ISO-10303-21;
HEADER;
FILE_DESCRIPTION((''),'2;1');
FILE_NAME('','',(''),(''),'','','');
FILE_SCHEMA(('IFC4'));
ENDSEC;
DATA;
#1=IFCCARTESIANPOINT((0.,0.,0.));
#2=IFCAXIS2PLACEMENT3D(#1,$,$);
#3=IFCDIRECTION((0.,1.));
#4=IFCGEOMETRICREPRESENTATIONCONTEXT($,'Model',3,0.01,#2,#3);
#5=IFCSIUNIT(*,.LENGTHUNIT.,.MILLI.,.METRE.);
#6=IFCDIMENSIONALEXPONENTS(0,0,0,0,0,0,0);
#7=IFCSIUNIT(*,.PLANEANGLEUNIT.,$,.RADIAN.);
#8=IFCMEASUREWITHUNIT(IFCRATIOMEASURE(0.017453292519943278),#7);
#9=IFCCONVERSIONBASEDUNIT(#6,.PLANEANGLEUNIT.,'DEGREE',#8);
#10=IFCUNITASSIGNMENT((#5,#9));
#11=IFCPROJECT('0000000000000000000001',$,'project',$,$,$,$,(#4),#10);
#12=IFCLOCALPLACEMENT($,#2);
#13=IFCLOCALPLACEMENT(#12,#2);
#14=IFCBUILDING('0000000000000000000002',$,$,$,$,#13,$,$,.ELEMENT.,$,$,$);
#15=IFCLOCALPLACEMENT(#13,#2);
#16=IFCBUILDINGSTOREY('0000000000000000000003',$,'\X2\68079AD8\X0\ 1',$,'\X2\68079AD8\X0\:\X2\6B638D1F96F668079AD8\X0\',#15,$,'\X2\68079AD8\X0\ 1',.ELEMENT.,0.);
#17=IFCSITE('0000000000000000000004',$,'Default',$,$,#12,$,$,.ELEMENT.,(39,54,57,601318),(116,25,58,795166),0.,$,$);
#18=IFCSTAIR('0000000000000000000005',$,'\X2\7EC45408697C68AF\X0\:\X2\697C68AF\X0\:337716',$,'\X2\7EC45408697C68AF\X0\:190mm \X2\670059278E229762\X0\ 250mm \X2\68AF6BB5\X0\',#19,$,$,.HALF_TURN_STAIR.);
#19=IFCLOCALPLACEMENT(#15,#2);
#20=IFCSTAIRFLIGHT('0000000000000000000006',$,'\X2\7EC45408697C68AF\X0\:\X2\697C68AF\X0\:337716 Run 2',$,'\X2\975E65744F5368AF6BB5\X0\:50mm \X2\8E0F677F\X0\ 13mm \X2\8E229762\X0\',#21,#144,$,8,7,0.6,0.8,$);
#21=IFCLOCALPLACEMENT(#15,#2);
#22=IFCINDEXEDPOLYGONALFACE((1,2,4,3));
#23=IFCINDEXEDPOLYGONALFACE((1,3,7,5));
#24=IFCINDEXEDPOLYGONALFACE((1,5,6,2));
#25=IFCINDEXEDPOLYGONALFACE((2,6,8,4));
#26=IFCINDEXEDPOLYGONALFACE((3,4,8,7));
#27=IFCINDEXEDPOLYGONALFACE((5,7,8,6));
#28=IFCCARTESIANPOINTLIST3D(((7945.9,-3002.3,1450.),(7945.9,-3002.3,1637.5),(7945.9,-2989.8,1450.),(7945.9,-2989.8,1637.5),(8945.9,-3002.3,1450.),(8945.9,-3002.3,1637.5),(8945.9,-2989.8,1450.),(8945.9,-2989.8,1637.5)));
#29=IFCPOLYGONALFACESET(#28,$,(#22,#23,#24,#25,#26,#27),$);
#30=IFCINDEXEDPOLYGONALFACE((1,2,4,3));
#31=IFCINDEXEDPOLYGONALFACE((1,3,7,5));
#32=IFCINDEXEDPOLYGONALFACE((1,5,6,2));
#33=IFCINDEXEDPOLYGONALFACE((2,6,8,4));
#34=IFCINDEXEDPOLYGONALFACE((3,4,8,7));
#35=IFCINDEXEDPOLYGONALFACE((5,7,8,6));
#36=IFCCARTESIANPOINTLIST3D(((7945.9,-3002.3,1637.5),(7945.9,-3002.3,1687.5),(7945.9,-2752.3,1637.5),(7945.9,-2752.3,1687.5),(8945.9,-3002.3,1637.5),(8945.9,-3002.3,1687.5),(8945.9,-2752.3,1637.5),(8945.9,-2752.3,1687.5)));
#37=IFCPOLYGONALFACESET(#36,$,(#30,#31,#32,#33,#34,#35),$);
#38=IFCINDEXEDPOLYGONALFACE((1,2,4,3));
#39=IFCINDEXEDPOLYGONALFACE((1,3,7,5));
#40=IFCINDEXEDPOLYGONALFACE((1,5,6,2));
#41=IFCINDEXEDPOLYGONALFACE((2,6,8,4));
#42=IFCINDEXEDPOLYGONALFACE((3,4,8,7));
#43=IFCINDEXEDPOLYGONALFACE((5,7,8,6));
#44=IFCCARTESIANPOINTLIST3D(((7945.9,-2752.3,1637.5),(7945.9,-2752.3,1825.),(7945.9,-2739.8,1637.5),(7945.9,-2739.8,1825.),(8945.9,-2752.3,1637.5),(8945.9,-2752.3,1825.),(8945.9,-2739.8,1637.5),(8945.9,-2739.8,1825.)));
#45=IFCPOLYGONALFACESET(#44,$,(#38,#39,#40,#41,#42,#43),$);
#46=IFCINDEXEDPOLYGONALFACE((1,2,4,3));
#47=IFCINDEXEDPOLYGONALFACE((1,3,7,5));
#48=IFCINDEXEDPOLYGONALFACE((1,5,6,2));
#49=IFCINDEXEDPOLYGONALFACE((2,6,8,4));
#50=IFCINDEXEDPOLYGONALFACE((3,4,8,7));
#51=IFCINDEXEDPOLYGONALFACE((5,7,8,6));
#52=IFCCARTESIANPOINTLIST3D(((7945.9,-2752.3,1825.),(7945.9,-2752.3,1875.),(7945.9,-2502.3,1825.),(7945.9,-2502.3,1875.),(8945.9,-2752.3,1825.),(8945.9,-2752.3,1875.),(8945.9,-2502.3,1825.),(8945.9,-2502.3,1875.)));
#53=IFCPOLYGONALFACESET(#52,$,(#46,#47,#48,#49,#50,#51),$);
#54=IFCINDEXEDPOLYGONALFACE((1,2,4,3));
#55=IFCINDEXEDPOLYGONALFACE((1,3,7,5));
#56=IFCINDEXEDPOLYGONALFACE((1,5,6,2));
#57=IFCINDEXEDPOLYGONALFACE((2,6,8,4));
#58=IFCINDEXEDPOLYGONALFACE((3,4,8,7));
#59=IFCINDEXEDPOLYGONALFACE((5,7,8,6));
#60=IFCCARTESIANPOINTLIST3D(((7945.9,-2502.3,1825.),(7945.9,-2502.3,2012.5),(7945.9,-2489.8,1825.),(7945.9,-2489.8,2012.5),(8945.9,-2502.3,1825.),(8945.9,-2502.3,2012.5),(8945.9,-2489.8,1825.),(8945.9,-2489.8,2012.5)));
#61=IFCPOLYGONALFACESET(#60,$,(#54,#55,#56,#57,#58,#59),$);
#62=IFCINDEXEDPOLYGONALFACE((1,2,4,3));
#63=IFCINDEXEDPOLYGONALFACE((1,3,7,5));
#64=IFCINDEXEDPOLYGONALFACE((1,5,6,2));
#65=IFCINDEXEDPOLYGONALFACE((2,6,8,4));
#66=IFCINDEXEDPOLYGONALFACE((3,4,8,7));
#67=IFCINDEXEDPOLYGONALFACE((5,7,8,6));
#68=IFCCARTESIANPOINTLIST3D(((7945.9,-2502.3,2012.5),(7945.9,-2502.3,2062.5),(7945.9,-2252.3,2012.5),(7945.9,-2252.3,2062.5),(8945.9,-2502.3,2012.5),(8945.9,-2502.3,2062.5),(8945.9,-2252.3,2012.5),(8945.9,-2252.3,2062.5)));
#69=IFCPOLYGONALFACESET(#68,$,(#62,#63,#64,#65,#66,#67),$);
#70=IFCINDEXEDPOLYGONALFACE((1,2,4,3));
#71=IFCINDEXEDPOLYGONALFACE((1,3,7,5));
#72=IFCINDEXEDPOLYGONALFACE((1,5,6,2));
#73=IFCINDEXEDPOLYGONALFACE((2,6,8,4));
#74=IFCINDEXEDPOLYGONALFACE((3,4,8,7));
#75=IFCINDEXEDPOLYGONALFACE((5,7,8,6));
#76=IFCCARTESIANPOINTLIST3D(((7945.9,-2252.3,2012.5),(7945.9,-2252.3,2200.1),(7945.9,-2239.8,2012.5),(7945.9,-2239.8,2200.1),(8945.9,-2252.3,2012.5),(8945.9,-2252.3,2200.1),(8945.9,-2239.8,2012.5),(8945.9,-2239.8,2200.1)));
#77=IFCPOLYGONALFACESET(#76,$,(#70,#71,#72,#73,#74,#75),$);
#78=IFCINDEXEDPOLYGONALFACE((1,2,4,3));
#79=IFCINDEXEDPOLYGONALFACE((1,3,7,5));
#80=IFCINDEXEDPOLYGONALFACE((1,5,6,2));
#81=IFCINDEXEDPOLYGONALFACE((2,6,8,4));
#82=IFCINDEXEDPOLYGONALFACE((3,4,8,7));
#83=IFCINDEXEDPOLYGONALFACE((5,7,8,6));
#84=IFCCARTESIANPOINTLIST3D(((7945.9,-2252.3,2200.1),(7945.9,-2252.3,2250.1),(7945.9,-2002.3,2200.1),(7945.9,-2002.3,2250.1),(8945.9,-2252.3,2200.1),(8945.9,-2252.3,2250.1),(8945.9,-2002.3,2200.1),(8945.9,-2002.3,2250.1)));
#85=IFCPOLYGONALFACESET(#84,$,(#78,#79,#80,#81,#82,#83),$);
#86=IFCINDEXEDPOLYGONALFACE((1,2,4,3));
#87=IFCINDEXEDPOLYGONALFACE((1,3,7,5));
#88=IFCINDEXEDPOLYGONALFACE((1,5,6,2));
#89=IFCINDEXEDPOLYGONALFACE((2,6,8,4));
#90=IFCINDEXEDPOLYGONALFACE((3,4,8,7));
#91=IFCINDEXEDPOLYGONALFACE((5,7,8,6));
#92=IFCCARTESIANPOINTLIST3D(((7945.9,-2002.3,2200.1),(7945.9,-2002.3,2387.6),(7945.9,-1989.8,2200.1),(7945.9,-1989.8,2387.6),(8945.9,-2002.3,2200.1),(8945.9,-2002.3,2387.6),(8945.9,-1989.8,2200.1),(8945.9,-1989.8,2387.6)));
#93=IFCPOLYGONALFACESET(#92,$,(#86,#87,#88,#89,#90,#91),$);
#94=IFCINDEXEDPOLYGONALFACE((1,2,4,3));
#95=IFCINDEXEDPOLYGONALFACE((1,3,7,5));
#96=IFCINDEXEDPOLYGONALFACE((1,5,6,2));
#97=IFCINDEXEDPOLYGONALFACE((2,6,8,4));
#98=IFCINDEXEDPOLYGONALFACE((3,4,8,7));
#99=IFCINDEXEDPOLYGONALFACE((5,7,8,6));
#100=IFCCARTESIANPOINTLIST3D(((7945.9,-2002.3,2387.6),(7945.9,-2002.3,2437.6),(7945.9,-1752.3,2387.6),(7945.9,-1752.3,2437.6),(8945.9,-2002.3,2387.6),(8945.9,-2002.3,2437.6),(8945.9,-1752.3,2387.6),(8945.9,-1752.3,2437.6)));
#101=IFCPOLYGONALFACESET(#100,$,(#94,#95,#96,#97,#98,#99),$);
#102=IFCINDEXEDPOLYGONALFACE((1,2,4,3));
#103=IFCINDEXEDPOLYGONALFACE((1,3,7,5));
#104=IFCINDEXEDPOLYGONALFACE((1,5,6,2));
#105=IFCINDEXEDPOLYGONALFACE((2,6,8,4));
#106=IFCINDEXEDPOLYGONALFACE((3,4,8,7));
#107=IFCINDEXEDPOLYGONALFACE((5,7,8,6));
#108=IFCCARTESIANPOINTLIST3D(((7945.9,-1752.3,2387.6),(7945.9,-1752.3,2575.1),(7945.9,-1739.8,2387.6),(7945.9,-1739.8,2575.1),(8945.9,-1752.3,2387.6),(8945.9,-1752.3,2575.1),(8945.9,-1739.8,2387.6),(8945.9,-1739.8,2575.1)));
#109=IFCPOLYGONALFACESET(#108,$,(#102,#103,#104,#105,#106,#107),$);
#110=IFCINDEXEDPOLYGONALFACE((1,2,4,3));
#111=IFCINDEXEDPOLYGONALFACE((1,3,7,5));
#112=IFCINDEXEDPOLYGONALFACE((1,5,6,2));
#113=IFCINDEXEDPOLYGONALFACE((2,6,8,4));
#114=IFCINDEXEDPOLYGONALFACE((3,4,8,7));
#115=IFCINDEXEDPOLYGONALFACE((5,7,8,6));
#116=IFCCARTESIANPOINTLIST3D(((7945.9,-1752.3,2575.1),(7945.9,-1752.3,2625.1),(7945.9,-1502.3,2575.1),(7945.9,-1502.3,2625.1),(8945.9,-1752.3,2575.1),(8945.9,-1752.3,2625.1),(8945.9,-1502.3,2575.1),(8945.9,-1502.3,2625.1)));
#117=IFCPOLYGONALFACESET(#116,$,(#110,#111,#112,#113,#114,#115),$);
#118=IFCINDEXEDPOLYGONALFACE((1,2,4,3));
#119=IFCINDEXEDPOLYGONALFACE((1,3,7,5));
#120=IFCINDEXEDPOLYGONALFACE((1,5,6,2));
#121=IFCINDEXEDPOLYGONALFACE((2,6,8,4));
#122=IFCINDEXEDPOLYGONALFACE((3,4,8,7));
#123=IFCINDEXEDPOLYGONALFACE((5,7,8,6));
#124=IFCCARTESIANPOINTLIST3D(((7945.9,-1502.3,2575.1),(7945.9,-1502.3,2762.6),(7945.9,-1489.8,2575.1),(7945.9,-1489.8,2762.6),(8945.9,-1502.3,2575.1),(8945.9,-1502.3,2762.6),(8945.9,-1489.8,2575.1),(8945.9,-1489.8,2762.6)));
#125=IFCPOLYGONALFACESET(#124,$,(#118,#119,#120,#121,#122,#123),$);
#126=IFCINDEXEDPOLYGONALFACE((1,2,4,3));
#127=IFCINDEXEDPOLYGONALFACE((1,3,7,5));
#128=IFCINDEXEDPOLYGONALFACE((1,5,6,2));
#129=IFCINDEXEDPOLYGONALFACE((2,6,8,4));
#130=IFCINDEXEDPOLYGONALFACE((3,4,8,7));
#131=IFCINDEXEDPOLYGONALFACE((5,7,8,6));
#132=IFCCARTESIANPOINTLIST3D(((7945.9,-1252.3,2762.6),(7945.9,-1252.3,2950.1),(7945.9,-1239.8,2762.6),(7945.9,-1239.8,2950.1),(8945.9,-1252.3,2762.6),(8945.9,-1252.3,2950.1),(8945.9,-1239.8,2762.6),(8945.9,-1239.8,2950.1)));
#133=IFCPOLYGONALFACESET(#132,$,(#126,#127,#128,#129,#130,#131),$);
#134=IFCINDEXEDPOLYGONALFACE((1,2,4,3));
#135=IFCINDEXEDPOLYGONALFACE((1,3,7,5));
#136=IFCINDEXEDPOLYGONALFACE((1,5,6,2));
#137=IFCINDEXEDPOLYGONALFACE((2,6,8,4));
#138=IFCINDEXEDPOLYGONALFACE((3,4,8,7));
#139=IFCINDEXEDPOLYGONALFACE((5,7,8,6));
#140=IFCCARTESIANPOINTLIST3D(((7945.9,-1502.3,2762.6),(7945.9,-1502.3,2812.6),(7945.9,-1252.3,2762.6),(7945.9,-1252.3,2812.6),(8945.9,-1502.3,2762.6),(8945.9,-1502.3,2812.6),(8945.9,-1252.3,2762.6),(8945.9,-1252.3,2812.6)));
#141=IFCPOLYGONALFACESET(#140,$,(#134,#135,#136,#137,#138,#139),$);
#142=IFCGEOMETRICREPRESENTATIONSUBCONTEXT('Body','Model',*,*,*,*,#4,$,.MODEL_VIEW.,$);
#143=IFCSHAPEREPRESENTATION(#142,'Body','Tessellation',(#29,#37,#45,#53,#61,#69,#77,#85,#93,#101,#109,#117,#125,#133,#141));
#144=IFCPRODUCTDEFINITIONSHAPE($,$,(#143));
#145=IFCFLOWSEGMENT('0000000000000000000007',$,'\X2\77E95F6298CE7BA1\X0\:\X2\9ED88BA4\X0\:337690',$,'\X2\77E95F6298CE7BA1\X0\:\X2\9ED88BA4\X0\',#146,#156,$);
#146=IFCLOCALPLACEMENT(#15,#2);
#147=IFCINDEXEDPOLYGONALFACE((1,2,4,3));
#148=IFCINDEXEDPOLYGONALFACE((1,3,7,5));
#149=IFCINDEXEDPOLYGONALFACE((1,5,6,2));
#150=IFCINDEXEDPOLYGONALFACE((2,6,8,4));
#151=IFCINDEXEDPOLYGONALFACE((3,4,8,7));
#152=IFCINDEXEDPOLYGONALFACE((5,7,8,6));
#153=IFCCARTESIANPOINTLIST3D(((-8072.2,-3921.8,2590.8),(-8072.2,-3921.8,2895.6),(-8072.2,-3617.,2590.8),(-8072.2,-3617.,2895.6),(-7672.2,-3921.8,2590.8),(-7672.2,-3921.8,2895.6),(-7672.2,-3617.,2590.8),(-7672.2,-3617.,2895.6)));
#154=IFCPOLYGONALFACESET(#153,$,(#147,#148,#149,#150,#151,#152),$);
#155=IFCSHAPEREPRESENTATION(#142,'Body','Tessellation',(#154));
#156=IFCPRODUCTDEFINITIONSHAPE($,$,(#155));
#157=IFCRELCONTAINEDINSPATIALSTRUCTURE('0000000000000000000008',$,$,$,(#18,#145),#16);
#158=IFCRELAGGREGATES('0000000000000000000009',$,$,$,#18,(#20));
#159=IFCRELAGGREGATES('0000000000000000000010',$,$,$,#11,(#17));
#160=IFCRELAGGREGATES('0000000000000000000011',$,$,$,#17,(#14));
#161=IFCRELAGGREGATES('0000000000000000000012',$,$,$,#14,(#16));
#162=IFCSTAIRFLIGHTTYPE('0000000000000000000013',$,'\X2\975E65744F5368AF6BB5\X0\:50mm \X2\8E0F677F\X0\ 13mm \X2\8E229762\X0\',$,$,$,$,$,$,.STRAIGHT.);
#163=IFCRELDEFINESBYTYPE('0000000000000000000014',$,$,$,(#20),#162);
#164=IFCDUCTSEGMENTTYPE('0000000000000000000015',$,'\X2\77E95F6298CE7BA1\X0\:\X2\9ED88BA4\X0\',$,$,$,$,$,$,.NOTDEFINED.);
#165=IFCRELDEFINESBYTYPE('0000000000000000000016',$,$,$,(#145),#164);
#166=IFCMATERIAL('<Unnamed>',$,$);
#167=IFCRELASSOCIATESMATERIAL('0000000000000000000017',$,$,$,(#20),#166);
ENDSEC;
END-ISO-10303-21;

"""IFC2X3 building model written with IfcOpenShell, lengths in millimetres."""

from ifc_helpers import new_model, entity, si_unit, converted_unit, direction, frame, frame_2d, origin, origin_2d_with_axis, place, context, subcontext, project, spatial, rectangle, extrude, material, type_object, element, aggregate, save


model = new_model("IFC2X3")

# Units and contexts
model_context = context("Model", 3, precision=0.01, world=origin(), true_north=direction((0.0, 1.0)))
body_context = subcontext(model_context, "Body", "Model", "MODEL_VIEW")
ifc_project = project(units=[si_unit("LENGTHUNIT", "METRE", prefix="MILLI"), converted_unit("PLANEANGLEUNIT", "DEGREE", entity("IfcRatioMeasure", 0.017453292519943278), si_unit("PLANEANGLEUNIT", "RADIAN"), dimensions=[0, 0, 0, 0, 0, 0, 0])], contexts=[model_context])

# Site, building, storey
site_placement = place(None, origin())
site = spatial("IfcSite", under=ifc_project, at=site_placement, Name="Default", CompositionType="ELEMENT", RefLatitude=(39, 54, 57, 601318), RefLongitude=(116, 25, 58, 795166), RefElevation=0.0)
building_placement = place(site_placement, origin())
building = spatial("IfcBuilding", under=site, at=building_placement, CompositionType="ELEMENT")
storey_placement = place(building_placement, origin())
storey = spatial("IfcBuildingStorey", under=building, at=storey_placement, Name="标高 1", ObjectType="标高:正负零标高", LongName="标高 1", CompositionType="ELEMENT", Elevation=0.0)

# Stair
stair_placement = place(storey_placement, origin())
stair = element("IfcStair", 1, at=stair_placement, inside=storey, Name="组合楼梯:楼梯:337716", ObjectType="组合楼梯:190mm 最大踢面 250mm 梯段", ShapeType="HALF_TURN_STAIR")
ifc_material_1 = material(Name="<Unnamed>")

# Stair flight
stair_flight_type = type_object("IfcStairFlightType", Name="非整体梯段:50mm 踏板 13mm 踢面", PredefinedType="STRAIGHT")
stair_flight_1_placement = place(stair_placement, origin())
stair_flight_1 = element("IfcStairFlight", 2, at=stair_flight_1_placement, type_object=stair_flight_type, material=ifc_material_1, Name="组合楼梯:楼梯:337716 Run 2", ObjectType="非整体梯段:50mm 踏板 13mm 踢面", NumberOfRiser=8, NumberOfTreads=7, RiserHeight=0.6, TreadLength=0.8, context=body_context, shape_type="SweptSolid", body=[
    extrude(rectangle(XDim=1000.0, YDim=12.5, at=frame_2d((0.0, 0.0), x_axis=(1.0, 0.0))), frame((8445.9, -2996.0, 1450.0), z_axis=(0.0, 0.0, 1.0), x_axis=(-1.0, 0.0, 0.0)), (0.0, 0.0, 1.0), 187.5),
    extrude(rectangle(XDim=250.0, YDim=1000.0, at=frame_2d((0.0, 0.0), x_axis=(1.0, 0.0))), frame((8445.9, -2877.3, 1637.5), z_axis=(0.0, 0.0, 1.0), x_axis=(0.0, -1.0, 0.0)), (0.0, 0.0, 1.0), 50.0),
    extrude(rectangle(XDim=1000.0, YDim=12.5, at=frame_2d((0.0, 0.0), x_axis=(1.0, 0.0))), frame((8445.9, -2746.0, 1637.5), z_axis=(0.0, 0.0, 1.0), x_axis=(-1.0, 0.0, 0.0)), (0.0, 0.0, 1.0), 187.5),
    extrude(rectangle(XDim=250.0, YDim=1000.0, at=frame_2d((0.0, 0.0), x_axis=(1.0, 0.0))), frame((8445.9, -2627.3, 1825.0), z_axis=(0.0, 0.0, 1.0), x_axis=(0.0, -1.0, 0.0)), (0.0, 0.0, 1.0), 50.0),
    extrude(rectangle(XDim=1000.0, YDim=12.5, at=frame_2d((0.0, 0.0), x_axis=(1.0, 0.0))), frame((8445.9, -2496.0, 1825.0), z_axis=(0.0, 0.0, 1.0), x_axis=(-1.0, 0.0, 0.0)), (0.0, 0.0, 1.0), 187.5),
    extrude(rectangle(XDim=250.0, YDim=1000.0, at=frame_2d((0.0, 0.0), x_axis=(1.0, 0.0))), frame((8445.9, -2377.3, 2012.5), z_axis=(0.0, 0.0, 1.0), x_axis=(0.0, -1.0, 0.0)), (0.0, 0.0, 1.0), 50.0),
    extrude(rectangle(XDim=1000.0, YDim=12.5, at=frame_2d((0.0, 0.0), x_axis=(1.0, 0.0))), frame((8445.9, -2246.0, 2012.5), z_axis=(0.0, 0.0, 1.0), x_axis=(-1.0, 0.0, 0.0)), (0.0, 0.0, 1.0), 187.5),
    extrude(rectangle(XDim=250.0, YDim=1000.0, at=frame_2d((0.0, 0.0), x_axis=(1.0, 0.0))), frame((8445.9, -2127.3, 2200.1), z_axis=(0.0, 0.0, 1.0), x_axis=(0.0, -1.0, 0.0)), (0.0, 0.0, 1.0), 50.0),
    extrude(rectangle(XDim=1000.0, YDim=12.5, at=frame_2d((0.0, 0.0), x_axis=(1.0, 0.0))), frame((8445.9, -1996.0, 2200.1), z_axis=(0.0, 0.0, 1.0), x_axis=(-1.0, 0.0, 0.0)), (0.0, 0.0, 1.0), 187.5),
    extrude(rectangle(XDim=250.0, YDim=1000.0, at=frame_2d((0.0, 0.0), x_axis=(1.0, 0.0))), frame((8445.9, -1877.3, 2387.6), z_axis=(0.0, 0.0, 1.0), x_axis=(0.0, -1.0, 0.0)), (0.0, 0.0, 1.0), 50.0),
    extrude(rectangle(XDim=1000.0, YDim=12.5, at=origin_2d_with_axis()), frame((8445.9, -1746.0, 2387.6), z_axis=(0.0, 0.0, 1.0), x_axis=(-1.0, 0.0, 0.0)), (0.0, 0.0, 1.0), 187.5),
    extrude(rectangle(XDim=250.0, YDim=1000.0, at=frame_2d((0.0, 0.0), x_axis=(1.0, 0.0))), frame((8445.9, -1627.3, 2575.1), z_axis=(0.0, 0.0, 1.0), x_axis=(0.0, -1.0, 0.0)), (0.0, 0.0, 1.0), 50.0),
    extrude(rectangle(XDim=1000.0, YDim=12.5, at=origin_2d_with_axis()), frame((8445.9, -1496.0, 2575.1), z_axis=(0.0, 0.0, 1.0), x_axis=(-1.0, 0.0, 0.0)), (0.0, 0.0, 1.0), 187.5),
    extrude(rectangle(XDim=1000.0, YDim=12.5, at=origin_2d_with_axis()), frame((8445.9, -1246.0, 2762.6), z_axis=(0.0, 0.0, 1.0), x_axis=(-1.0, 0.0, 0.0)), (0.0, 0.0, 1.0), 187.5),
    extrude(rectangle(XDim=250.0, YDim=1000.0, at=frame_2d((0.0, 0.0), x_axis=(1.0, 0.0))), frame((8445.9, -1377.3, 2762.6), z_axis=(0.0, 0.0, 1.0), x_axis=(0.0, -1.0, 0.0)), (0.0, 0.0, 1.0), 50.0),
])
aggregate(stair, [stair_flight_1])

# Flow segment
duct_segment_type = type_object("IfcDuctSegmentType", Name="矩形风管:默认", PredefinedType="NOTDEFINED")
flow_segment_placement = place(storey_placement, origin())
element("IfcFlowSegment", 3, at=flow_segment_placement, inside=storey, type_object=duct_segment_type, Name="矩形风管:默认:337690", ObjectType="矩形风管:默认", context=body_context, shape_type="SweptSolid", body=[
    extrude(rectangle(XDim=400.0, YDim=304.8, at=frame_2d((0.0, 0.0), x_axis=(1.0, 0.0))), frame((-7872.2, -3769.4, 2590.8), z_axis=(0.0, 0.0, 1.0), x_axis=(-1.0, 0.0, 0.0)), (0.0, 0.0, 1.0), 304.8),
])

save(model, "model.ifc")
